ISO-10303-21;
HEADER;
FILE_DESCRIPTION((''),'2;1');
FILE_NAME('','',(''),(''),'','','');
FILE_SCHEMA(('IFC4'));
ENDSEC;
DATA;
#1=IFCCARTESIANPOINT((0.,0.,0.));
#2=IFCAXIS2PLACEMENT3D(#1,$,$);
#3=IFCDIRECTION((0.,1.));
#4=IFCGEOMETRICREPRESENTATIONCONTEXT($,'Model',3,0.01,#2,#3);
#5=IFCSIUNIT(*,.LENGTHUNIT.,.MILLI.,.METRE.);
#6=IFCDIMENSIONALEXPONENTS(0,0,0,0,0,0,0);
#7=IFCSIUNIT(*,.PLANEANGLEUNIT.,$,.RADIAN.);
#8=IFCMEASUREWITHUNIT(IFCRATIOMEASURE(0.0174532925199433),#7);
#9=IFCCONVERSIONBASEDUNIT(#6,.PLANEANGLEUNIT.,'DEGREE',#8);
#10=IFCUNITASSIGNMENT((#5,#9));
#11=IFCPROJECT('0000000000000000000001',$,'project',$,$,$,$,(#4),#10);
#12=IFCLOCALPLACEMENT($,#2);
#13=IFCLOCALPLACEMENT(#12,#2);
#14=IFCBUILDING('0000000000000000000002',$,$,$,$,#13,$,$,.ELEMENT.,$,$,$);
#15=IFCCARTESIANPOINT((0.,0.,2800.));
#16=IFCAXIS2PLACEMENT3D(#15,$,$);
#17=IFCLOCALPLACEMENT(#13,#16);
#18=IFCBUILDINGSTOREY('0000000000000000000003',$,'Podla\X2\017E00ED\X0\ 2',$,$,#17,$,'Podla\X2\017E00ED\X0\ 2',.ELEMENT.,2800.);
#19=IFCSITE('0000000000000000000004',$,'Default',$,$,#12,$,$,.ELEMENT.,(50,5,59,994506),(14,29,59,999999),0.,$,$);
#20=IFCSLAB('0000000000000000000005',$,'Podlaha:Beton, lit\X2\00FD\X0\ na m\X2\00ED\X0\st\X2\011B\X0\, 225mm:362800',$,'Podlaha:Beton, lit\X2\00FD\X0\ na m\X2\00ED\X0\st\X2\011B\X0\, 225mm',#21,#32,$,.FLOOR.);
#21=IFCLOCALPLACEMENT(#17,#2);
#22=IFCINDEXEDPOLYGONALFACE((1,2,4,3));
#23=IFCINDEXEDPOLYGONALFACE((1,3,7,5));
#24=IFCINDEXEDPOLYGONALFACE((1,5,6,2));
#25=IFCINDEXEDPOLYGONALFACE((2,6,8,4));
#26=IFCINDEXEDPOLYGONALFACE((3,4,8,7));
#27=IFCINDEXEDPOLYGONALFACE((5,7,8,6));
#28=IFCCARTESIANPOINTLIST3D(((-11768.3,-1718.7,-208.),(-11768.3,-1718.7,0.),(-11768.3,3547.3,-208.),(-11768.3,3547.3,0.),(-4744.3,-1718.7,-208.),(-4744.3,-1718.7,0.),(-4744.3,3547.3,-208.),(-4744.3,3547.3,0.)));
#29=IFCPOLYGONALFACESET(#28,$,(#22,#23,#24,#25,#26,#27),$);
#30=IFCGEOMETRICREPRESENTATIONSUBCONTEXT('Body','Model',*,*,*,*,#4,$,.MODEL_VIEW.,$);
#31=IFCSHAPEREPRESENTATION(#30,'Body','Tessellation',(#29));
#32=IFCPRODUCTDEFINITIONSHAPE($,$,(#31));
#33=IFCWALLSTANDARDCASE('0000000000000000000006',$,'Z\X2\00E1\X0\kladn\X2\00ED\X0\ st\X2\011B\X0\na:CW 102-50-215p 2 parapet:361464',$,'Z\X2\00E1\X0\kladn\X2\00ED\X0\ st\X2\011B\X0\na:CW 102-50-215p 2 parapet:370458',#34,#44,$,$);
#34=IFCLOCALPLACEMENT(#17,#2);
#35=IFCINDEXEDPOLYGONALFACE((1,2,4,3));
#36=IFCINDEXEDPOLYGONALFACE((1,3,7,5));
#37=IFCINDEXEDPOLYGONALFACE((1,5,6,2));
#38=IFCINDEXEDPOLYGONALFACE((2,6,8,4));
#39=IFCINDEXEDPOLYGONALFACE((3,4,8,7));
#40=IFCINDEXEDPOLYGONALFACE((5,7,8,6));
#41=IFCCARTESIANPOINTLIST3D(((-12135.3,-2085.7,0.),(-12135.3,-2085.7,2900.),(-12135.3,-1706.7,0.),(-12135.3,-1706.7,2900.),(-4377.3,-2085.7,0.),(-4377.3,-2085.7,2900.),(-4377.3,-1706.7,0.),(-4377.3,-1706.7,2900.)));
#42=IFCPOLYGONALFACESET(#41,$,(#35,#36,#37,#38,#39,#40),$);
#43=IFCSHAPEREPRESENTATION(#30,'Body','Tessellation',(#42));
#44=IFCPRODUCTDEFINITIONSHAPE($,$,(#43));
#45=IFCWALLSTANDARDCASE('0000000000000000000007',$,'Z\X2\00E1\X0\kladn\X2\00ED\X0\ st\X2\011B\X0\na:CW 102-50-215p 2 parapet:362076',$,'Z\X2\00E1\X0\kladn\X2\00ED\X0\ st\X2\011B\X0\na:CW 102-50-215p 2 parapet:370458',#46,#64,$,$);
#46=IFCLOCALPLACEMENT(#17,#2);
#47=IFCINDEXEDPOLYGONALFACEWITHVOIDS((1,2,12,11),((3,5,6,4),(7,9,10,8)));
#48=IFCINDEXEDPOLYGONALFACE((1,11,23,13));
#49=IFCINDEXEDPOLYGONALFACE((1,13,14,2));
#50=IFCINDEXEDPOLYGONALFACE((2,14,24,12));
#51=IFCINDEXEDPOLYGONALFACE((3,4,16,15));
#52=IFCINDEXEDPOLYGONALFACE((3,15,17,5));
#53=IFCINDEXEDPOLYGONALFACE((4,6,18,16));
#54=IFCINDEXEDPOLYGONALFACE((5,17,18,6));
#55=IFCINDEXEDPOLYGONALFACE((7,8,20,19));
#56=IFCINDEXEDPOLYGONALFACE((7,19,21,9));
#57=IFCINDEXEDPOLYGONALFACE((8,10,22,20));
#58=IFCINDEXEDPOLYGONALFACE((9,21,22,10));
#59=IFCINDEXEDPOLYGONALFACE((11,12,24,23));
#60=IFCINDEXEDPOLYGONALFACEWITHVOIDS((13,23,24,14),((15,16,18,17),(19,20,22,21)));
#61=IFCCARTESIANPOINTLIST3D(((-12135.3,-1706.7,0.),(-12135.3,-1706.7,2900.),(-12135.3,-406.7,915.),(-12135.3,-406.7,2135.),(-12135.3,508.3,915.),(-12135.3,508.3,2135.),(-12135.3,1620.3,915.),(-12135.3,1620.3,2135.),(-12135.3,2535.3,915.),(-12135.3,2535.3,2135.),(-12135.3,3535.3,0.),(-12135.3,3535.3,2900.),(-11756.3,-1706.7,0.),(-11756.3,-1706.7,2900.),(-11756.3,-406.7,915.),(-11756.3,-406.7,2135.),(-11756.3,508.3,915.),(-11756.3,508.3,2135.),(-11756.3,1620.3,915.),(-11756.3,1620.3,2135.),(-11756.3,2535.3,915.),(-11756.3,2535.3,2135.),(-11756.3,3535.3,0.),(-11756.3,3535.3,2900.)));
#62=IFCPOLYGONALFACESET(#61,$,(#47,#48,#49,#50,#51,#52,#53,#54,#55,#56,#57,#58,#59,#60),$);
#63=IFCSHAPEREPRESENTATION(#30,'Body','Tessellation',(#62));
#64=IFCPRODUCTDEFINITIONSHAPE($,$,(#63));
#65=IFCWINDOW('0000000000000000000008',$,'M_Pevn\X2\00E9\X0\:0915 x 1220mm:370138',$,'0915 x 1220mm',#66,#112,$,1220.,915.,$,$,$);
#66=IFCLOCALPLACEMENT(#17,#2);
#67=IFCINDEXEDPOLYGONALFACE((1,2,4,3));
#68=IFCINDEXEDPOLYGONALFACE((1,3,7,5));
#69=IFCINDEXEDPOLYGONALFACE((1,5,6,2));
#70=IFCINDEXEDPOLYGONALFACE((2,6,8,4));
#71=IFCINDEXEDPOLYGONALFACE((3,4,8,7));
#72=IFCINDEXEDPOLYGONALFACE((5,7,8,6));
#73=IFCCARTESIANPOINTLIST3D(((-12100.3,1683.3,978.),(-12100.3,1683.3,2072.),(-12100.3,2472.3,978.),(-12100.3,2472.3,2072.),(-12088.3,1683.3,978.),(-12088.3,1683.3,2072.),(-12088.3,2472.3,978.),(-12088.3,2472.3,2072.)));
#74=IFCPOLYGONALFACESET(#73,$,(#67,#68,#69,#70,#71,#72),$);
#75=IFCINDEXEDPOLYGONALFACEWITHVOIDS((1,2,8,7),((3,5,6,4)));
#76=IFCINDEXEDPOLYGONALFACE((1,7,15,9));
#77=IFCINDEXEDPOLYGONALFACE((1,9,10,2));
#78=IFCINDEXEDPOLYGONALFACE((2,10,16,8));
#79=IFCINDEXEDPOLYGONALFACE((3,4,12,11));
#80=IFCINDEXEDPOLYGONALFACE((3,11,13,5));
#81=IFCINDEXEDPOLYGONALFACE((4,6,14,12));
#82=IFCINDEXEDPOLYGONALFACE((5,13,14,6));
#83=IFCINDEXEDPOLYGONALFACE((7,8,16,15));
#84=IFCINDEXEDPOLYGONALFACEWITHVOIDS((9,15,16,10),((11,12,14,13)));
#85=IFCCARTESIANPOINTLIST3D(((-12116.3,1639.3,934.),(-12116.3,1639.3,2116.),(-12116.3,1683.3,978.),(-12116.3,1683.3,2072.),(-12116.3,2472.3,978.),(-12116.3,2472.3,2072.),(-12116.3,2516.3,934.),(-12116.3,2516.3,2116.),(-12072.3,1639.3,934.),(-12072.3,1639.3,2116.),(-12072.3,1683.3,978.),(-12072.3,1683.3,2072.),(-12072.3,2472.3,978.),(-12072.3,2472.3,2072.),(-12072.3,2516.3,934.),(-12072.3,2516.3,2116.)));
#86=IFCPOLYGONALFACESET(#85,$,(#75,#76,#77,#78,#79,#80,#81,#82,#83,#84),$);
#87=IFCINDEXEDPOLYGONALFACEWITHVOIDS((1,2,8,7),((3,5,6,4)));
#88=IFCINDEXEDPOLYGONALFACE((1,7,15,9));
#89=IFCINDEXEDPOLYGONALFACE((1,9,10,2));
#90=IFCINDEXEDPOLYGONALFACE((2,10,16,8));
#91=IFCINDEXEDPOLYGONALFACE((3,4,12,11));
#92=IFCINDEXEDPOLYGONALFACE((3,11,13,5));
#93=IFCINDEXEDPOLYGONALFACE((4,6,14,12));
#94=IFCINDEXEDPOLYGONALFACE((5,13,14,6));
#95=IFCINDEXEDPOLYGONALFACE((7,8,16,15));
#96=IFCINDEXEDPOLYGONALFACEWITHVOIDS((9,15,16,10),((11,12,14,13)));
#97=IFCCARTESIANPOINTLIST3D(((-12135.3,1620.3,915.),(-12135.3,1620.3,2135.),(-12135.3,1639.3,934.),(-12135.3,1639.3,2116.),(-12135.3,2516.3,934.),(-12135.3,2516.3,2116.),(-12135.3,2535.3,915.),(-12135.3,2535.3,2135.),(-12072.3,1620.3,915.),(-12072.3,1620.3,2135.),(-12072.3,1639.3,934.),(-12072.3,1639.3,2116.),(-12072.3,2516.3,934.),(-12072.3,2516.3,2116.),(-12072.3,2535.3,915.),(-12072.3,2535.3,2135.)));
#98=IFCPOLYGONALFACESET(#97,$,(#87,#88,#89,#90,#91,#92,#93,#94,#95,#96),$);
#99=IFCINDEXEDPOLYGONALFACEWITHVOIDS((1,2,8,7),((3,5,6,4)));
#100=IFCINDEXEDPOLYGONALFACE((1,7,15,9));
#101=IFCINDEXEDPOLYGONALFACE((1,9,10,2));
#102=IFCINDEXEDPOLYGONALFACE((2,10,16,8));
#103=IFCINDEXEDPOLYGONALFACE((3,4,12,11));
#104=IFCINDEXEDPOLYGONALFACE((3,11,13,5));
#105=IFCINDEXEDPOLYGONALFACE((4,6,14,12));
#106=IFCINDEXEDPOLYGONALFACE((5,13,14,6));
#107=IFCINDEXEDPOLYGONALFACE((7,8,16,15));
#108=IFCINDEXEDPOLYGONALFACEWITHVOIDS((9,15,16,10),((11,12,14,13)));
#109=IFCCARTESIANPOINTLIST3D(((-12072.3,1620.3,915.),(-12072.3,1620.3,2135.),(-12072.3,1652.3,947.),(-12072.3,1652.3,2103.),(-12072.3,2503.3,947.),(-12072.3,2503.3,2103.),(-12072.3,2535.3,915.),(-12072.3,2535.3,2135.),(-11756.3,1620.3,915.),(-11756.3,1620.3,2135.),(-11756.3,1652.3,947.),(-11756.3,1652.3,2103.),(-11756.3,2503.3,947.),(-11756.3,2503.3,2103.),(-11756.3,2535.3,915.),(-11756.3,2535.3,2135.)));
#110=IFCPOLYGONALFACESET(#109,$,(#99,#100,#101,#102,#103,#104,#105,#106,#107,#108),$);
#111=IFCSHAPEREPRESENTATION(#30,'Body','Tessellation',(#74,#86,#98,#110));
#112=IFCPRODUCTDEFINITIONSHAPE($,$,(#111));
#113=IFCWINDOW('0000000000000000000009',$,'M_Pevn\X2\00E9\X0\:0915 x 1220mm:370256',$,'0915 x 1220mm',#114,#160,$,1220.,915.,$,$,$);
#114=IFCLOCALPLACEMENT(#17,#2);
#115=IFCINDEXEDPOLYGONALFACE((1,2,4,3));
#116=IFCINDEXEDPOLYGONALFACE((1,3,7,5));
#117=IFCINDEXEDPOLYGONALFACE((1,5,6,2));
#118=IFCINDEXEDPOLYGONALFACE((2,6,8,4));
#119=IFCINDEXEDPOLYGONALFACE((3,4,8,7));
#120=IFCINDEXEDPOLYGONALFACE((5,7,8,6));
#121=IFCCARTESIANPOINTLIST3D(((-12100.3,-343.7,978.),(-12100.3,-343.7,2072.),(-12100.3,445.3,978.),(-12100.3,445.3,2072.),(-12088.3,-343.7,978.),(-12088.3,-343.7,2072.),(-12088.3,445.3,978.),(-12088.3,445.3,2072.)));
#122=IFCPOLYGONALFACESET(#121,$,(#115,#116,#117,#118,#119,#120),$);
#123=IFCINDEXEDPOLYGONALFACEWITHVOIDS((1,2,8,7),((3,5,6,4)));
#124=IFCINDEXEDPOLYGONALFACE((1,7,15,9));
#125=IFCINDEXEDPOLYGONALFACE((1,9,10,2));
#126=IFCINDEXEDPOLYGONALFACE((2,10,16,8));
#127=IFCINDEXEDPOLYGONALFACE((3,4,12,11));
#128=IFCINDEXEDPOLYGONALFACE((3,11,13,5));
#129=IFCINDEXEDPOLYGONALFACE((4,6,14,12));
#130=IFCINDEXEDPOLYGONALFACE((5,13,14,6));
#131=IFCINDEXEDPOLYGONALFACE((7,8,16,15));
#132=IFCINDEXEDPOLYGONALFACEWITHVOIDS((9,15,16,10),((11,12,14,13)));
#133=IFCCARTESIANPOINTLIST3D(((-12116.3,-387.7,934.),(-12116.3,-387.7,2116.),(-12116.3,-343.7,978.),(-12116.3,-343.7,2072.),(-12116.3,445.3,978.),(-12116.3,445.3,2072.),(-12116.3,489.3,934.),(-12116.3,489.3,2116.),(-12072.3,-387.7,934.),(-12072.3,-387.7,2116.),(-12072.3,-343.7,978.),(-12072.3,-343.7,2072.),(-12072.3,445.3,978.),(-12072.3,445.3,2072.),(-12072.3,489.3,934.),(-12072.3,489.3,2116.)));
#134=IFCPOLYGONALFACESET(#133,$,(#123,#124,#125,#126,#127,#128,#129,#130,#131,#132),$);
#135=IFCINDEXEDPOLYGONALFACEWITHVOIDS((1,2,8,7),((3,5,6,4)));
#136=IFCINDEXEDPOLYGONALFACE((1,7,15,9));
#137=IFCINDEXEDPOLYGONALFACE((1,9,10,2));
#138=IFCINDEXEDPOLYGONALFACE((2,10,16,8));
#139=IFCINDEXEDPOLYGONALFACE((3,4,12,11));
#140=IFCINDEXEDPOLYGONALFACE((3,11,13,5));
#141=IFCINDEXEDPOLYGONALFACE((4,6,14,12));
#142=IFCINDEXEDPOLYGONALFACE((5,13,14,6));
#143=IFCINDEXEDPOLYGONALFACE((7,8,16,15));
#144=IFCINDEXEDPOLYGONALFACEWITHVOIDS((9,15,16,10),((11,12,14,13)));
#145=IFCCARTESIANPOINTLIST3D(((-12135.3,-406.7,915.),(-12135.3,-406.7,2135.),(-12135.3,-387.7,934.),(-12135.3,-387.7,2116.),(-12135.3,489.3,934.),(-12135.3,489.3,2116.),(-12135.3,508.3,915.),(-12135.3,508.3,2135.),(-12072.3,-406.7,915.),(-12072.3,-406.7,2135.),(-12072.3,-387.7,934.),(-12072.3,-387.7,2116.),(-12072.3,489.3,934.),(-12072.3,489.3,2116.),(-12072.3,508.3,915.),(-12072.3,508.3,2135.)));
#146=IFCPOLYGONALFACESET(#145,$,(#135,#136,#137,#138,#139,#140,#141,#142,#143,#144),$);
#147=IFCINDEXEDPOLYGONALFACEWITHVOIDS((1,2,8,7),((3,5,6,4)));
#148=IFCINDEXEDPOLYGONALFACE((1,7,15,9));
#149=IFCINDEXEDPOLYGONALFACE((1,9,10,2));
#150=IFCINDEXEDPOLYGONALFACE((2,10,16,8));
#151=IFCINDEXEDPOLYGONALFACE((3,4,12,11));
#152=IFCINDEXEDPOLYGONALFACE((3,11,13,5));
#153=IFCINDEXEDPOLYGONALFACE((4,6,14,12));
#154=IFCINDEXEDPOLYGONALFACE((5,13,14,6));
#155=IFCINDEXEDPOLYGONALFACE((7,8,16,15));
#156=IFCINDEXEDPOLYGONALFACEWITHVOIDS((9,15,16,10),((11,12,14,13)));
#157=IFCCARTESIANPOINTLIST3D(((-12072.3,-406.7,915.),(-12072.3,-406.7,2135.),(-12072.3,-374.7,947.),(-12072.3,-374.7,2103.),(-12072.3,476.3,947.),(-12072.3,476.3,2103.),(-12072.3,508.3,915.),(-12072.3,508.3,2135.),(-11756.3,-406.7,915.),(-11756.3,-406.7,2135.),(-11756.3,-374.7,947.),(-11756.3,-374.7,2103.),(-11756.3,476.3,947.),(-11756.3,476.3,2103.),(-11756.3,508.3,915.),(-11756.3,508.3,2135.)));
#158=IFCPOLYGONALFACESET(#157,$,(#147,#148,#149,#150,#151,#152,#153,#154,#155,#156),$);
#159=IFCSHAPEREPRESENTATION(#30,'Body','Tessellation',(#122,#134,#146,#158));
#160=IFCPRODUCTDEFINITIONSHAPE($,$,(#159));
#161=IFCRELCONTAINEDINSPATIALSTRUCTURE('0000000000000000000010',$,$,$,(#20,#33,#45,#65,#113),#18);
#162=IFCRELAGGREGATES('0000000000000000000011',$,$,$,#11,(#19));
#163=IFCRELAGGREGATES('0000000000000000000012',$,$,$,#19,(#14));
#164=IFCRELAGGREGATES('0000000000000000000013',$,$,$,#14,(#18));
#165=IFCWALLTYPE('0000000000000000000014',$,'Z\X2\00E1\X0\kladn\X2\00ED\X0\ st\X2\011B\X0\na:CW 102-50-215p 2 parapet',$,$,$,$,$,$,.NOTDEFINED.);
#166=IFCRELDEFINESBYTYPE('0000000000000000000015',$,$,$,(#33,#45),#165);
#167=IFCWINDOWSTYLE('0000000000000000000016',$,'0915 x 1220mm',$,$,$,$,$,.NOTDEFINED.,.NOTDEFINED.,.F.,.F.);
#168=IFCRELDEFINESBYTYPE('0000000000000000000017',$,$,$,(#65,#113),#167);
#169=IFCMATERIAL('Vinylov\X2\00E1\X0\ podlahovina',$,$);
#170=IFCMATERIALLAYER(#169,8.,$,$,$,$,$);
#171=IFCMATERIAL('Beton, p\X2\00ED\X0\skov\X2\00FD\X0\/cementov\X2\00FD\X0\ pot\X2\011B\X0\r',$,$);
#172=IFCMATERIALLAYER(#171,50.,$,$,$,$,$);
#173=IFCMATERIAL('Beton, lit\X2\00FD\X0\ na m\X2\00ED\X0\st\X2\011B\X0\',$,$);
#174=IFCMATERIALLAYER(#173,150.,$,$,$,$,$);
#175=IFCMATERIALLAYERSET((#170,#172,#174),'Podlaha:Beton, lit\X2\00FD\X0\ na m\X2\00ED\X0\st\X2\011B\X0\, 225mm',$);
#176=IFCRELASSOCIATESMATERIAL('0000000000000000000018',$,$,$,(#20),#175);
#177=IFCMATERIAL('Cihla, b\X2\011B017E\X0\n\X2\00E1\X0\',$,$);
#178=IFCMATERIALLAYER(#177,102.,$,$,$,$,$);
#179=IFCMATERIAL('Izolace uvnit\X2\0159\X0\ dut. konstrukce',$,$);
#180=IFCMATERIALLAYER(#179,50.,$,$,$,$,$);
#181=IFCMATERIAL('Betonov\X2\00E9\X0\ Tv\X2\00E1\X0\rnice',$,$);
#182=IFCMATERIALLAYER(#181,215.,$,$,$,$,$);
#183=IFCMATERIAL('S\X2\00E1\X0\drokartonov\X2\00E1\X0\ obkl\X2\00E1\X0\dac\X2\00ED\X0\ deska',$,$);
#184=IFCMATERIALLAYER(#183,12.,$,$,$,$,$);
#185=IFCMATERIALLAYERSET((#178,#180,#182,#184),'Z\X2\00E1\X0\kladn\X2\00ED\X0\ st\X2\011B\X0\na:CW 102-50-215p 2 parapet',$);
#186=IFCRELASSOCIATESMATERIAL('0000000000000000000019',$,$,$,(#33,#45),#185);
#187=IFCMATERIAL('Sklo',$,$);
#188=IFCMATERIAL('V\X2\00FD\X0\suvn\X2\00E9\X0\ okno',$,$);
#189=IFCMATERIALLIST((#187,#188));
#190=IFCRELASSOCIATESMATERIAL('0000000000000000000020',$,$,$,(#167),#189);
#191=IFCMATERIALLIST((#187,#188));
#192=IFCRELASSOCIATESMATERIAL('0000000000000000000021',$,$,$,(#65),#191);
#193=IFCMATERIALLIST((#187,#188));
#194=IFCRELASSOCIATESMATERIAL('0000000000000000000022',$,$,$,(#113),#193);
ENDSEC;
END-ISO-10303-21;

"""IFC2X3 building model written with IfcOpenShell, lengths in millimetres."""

from ifc_helpers import new_model, entity, si_unit, converted_unit, direction, frame, frame_2d, origin, origin_2d_with_axis, place, context, subcontext, project, spatial, polyline, rectangle, outline, extrude, clip, halfspace, source, transform, mapped, material, material_list, layer, layer_set, layer_usage, type_object, type_shapes, element, fill, save


model = new_model("IFC2X3")

# Units and contexts
model_context = context("Model", 3, precision=0.01, world=origin(), true_north=direction((0.0, 1.0)))
body_context = subcontext(model_context, "Body", "Model", "MODEL_VIEW")
ifc_project = project(units=[si_unit("LENGTHUNIT", "METRE", prefix="MILLI"), converted_unit("PLANEANGLEUNIT", "DEGREE", entity("IfcRatioMeasure", 0.0174532925199433), si_unit("PLANEANGLEUNIT", "RADIAN"), dimensions=[0, 0, 0, 0, 0, 0, 0])], contexts=[model_context])

# Site, building, storey
site_placement = place(None, origin())
site = spatial("IfcSite", under=ifc_project, at=site_placement, Name="Default", CompositionType="ELEMENT", RefLatitude=(50, 5, 59, 994506), RefLongitude=(14, 29, 59, 999999), RefElevation=0.0)
building_placement = place(site_placement, origin())
building = spatial("IfcBuilding", under=site, at=building_placement, CompositionType="ELEMENT")
storey_placement = place(building_placement, frame((0.0, 0.0, 2800.0)))
storey = spatial("IfcBuildingStorey", under=building, at=storey_placement, Name="Podlaží 2", LongName="Podlaží 2", CompositionType="ELEMENT", Elevation=2800.0)

# Slab
ifc_material_1 = material(Name="Vinylová podlahovina")
ifc_layer_1 = layer(ifc_material_1, 8.0)
ifc_material_2 = material(Name="Beton, pískový/cementový potěr")
ifc_layer_2 = layer(ifc_material_2, 50.0)
ifc_material_3 = material(Name="Beton, litý na místě")
ifc_layer_3 = layer(ifc_material_3, 150.0)
ifc_layer_set_1 = layer_set([ifc_layer_1, ifc_layer_2, ifc_layer_3], Name="Podlaha:Beton, litý na místě, 225mm")
ifc_layer_usage_1 = layer_usage(ifc_layer_set_1, "AXIS3", "POSITIVE", 0.0)
slab_placement = place(storey_placement, origin())
element("IfcSlab", 1, at=slab_placement, inside=storey, material=ifc_layer_usage_1, Name="Podlaha:Beton, litý na místě, 225mm:362800", ObjectType="Podlaha:Beton, litý na místě, 225mm", PredefinedType="FLOOR", context=body_context, shape_type="SweptSolid", body=[
    extrude(rectangle(XDim=5266.0, YDim=7024.0, at=frame_2d((0.0, 0.0), x_axis=(1.0, 0.0))), frame((-8256.3, 914.3, 0.0), z_axis=(0.0, 0.0, -1.0), x_axis=(0.0, 1.0, 0.0)), (0.0, 0.0, 1.0), 208.0),
])

# Wall
ifc_material_4 = material(Name="Cihla, běžná")
ifc_layer_4 = layer(ifc_material_4, 102.0)
ifc_material_5 = material(Name="Izolace uvnitř dut. konstrukce")
ifc_layer_5 = layer(ifc_material_5, 50.0)
ifc_material_6 = material(Name="Betonové Tvárnice")
ifc_layer_6 = layer(ifc_material_6, 215.0)
ifc_material_7 = material(Name="Sádrokartonová obkládací deska")
ifc_layer_7 = layer(ifc_material_7, 12.0)
ifc_layer_set_2 = layer_set([ifc_layer_4, ifc_layer_5, ifc_layer_6, ifc_layer_7], Name="Základní stěna:CW 102-50-215p 2 parapet")
ifc_layer_usage_2 = layer_usage(ifc_layer_set_2, "AXIS2", "POSITIVE", -189.5)
wall_type_1 = type_object("IfcWallType", Name="Základní stěna:CW 102-50-215p 2 parapet", PredefinedType="NOTDEFINED")
wall_1_placement = place(storey_placement, frame((-12135.3, -1896.2, 0.0)))
element("IfcWallStandardCase", 2, at=wall_1_placement, inside=storey, type_object=wall_type_1, material=ifc_layer_usage_2, Name="Základní stěna:CW 102-50-215p 2 parapet:361464", ObjectType="Základní stěna:CW 102-50-215p 2 parapet:370458", context=body_context, shape_type="Clipping", body=[
    clip(extrude(rectangle(XDim=7758.0, YDim=379.0, at=frame_2d((3879.0, 0.0), x_axis=(-1.0, 0.0))), origin(), (0.0, 0.0, 1.0), 2900.0), halfspace(frame((0.0, 0.0, -2800.0)), True)),
])

# Wall, openings, windows
ifc_material_8 = material(Name="Sklo")
ifc_material_9 = material(Name="Výsuvné okno")
ifc_material_list_1 = material_list([ifc_material_8, ifc_material_9])
window_style_1 = type_object("IfcWindowStyle", Name="0915 x 1220mm", ConstructionType="NOTDEFINED", OperationType="NOTDEFINED", ParameterTakesPrecedence=False, Sizeable=False, material=ifc_material_list_1)
shared_shape_1 = source(origin(), body_context, "Body", "SweptSolid", [
    extrude(rectangle(XDim=12.0, YDim=789.0, at=origin_2d_with_axis()), frame((457.5, 338.0, 63.0), z_axis=(0.0, 0.0, 1.0), x_axis=(0.0, -1.0, 0.0)), (0.0, 0.0, 1.0), 1094.0),
    extrude(outline(polyline([(-438.5, -591.0), (438.5, -591.0), (438.5, 591.0), (-438.5, 591.0), (-438.5, -591.0)]), holes=[polyline([(-394.5, -547.0), (-394.5, 547.0), (394.5, 547.0), (394.5, -547.0), (-394.5, -547.0)])]), frame((457.5, 316.0, 610.0), z_axis=(0.0, 1.0, 0.0), x_axis=(1.0, 0.0, 0.0)), (0.0, 0.0, 1.0), 44.0),
    extrude(outline(polyline([(-457.5, -610.0), (457.5, -610.0), (457.5, 610.0), (-457.5, 610.0), (-457.5, -610.0)]), holes=[polyline([(-438.5, -591.0), (-438.5, 591.0), (438.5, 591.0), (438.5, -591.0), (-438.5, -591.0)])]), frame((457.5, 316.0, 610.0), z_axis=(0.0, 1.0, 0.0), x_axis=(1.0, 0.0, 0.0)), (0.0, 0.0, 1.0), 63.0),
    extrude(outline(polyline([(-457.5, -610.0), (457.5, -610.0), (457.5, 610.0), (-457.5, 610.0), (-457.5, -610.0)]), holes=[polyline([(-425.5, -578.0), (-425.5, 578.0), (425.5, 578.0), (425.5, -578.0), (-425.5, -578.0)])]), frame((457.5, 0.0, 610.0), z_axis=(0.0, 1.0, 0.0), x_axis=(1.0, 0.0, 0.0)), (0.0, 0.0, 1.0), 316.0),
])
type_shapes(window_style_1, [shared_shape_1])
ifc_layer_usage_3 = layer_usage(ifc_layer_set_2, "AXIS2", "POSITIVE", -189.5)
wall_2_placement = place(storey_placement, frame((-11945.8, 3535.3, 0.0), z_axis=(0.0, 0.0, 1.0), x_axis=(0.0, -1.0, 0.0)))
wall_2 = element("IfcWallStandardCase", 3, at=wall_2_placement, inside=storey, type_object=wall_type_1, material=ifc_layer_usage_3, Name="Základní stěna:CW 102-50-215p 2 parapet:362076", ObjectType="Základní stěna:CW 102-50-215p 2 parapet:370458", context=body_context, shape_type="Clipping", body=[
    clip(extrude(rectangle(XDim=5242.0, YDim=379.0, at=frame_2d((2621.0, 0.0), x_axis=(-1.0, 0.0))), origin(), (0.0, 0.0, 1.0), 2900.0), halfspace(frame((0.0, 0.0, -2800.0)), True)),
])
opening_1_placement = place(wall_2_placement, frame((1915.0, 189.5, 915.0)))
opening_1 = element("IfcOpeningElement", 4, at=opening_1_placement, cuts=wall_2, ObjectType="Opening", context=body_context, shape_type="SweptSolid", body=[
    extrude(rectangle(XDim=1220.0, YDim=915.0, at=frame_2d((610.0, 457.5), x_axis=(1.0, 0.0))), frame((0.0, 0.0, 0.0), z_axis=(0.0, -1.0, 0.0), x_axis=(0.0, 0.0, 1.0)), (0.0, 0.0, 1.0), 379.0),
])
opening_2_placement = place(wall_2_placement, frame((3942.0, 189.5, 915.0)))
opening_2 = element("IfcOpeningElement", 5, at=opening_2_placement, cuts=wall_2, ObjectType="Opening", context=body_context, shape_type="SweptSolid", body=[
    extrude(rectangle(XDim=1220.0, YDim=915.0, at=frame_2d((610.0, 457.5), x_axis=(1.0, 0.0))), frame((0.0, 0.0, 0.0), z_axis=(0.0, -1.0, 0.0), x_axis=(0.0, 0.0, 1.0)), (0.0, 0.0, 1.0), 379.0),
])
ifc_material_list_2 = material_list([ifc_material_8, ifc_material_9])
window_1_placement = place(opening_1_placement, frame((0.0, 0.0, 0.0), z_axis=(0.0, 0.0, 1.0), x_axis=(-1.0, 0.0, 0.0)))
window_1 = element("IfcWindow", 6, at=window_1_placement, inside=storey, type_object=window_style_1, material=ifc_material_list_2, Name="M_Pevné:0915 x 1220mm:370138", ObjectType="0915 x 1220mm", OverallHeight=1220.0, OverallWidth=915.0, context=body_context, shape_type="MappedRepresentation", body=[
    mapped(shared_shape_1, transform((0.0, 0.0, 0.0), scale=1.0)),
])
fill(opening_1, window_1)
ifc_material_list_3 = material_list([ifc_material_8, ifc_material_9])
window_2_placement = place(opening_2_placement, frame((0.0, 0.0, 0.0), z_axis=(0.0, 0.0, 1.0), x_axis=(-1.0, 0.0, 0.0)))
window_2 = element("IfcWindow", 7, at=window_2_placement, inside=storey, type_object=window_style_1, material=ifc_material_list_3, Name="M_Pevné:0915 x 1220mm:370256", ObjectType="0915 x 1220mm", OverallHeight=1220.0, OverallWidth=915.0, context=body_context, shape_type="MappedRepresentation", body=[
    mapped(shared_shape_1, transform((0.0, 0.0, 0.0), scale=1.0)),
])
fill(opening_2, window_2)

save(model, "model.ifc")
